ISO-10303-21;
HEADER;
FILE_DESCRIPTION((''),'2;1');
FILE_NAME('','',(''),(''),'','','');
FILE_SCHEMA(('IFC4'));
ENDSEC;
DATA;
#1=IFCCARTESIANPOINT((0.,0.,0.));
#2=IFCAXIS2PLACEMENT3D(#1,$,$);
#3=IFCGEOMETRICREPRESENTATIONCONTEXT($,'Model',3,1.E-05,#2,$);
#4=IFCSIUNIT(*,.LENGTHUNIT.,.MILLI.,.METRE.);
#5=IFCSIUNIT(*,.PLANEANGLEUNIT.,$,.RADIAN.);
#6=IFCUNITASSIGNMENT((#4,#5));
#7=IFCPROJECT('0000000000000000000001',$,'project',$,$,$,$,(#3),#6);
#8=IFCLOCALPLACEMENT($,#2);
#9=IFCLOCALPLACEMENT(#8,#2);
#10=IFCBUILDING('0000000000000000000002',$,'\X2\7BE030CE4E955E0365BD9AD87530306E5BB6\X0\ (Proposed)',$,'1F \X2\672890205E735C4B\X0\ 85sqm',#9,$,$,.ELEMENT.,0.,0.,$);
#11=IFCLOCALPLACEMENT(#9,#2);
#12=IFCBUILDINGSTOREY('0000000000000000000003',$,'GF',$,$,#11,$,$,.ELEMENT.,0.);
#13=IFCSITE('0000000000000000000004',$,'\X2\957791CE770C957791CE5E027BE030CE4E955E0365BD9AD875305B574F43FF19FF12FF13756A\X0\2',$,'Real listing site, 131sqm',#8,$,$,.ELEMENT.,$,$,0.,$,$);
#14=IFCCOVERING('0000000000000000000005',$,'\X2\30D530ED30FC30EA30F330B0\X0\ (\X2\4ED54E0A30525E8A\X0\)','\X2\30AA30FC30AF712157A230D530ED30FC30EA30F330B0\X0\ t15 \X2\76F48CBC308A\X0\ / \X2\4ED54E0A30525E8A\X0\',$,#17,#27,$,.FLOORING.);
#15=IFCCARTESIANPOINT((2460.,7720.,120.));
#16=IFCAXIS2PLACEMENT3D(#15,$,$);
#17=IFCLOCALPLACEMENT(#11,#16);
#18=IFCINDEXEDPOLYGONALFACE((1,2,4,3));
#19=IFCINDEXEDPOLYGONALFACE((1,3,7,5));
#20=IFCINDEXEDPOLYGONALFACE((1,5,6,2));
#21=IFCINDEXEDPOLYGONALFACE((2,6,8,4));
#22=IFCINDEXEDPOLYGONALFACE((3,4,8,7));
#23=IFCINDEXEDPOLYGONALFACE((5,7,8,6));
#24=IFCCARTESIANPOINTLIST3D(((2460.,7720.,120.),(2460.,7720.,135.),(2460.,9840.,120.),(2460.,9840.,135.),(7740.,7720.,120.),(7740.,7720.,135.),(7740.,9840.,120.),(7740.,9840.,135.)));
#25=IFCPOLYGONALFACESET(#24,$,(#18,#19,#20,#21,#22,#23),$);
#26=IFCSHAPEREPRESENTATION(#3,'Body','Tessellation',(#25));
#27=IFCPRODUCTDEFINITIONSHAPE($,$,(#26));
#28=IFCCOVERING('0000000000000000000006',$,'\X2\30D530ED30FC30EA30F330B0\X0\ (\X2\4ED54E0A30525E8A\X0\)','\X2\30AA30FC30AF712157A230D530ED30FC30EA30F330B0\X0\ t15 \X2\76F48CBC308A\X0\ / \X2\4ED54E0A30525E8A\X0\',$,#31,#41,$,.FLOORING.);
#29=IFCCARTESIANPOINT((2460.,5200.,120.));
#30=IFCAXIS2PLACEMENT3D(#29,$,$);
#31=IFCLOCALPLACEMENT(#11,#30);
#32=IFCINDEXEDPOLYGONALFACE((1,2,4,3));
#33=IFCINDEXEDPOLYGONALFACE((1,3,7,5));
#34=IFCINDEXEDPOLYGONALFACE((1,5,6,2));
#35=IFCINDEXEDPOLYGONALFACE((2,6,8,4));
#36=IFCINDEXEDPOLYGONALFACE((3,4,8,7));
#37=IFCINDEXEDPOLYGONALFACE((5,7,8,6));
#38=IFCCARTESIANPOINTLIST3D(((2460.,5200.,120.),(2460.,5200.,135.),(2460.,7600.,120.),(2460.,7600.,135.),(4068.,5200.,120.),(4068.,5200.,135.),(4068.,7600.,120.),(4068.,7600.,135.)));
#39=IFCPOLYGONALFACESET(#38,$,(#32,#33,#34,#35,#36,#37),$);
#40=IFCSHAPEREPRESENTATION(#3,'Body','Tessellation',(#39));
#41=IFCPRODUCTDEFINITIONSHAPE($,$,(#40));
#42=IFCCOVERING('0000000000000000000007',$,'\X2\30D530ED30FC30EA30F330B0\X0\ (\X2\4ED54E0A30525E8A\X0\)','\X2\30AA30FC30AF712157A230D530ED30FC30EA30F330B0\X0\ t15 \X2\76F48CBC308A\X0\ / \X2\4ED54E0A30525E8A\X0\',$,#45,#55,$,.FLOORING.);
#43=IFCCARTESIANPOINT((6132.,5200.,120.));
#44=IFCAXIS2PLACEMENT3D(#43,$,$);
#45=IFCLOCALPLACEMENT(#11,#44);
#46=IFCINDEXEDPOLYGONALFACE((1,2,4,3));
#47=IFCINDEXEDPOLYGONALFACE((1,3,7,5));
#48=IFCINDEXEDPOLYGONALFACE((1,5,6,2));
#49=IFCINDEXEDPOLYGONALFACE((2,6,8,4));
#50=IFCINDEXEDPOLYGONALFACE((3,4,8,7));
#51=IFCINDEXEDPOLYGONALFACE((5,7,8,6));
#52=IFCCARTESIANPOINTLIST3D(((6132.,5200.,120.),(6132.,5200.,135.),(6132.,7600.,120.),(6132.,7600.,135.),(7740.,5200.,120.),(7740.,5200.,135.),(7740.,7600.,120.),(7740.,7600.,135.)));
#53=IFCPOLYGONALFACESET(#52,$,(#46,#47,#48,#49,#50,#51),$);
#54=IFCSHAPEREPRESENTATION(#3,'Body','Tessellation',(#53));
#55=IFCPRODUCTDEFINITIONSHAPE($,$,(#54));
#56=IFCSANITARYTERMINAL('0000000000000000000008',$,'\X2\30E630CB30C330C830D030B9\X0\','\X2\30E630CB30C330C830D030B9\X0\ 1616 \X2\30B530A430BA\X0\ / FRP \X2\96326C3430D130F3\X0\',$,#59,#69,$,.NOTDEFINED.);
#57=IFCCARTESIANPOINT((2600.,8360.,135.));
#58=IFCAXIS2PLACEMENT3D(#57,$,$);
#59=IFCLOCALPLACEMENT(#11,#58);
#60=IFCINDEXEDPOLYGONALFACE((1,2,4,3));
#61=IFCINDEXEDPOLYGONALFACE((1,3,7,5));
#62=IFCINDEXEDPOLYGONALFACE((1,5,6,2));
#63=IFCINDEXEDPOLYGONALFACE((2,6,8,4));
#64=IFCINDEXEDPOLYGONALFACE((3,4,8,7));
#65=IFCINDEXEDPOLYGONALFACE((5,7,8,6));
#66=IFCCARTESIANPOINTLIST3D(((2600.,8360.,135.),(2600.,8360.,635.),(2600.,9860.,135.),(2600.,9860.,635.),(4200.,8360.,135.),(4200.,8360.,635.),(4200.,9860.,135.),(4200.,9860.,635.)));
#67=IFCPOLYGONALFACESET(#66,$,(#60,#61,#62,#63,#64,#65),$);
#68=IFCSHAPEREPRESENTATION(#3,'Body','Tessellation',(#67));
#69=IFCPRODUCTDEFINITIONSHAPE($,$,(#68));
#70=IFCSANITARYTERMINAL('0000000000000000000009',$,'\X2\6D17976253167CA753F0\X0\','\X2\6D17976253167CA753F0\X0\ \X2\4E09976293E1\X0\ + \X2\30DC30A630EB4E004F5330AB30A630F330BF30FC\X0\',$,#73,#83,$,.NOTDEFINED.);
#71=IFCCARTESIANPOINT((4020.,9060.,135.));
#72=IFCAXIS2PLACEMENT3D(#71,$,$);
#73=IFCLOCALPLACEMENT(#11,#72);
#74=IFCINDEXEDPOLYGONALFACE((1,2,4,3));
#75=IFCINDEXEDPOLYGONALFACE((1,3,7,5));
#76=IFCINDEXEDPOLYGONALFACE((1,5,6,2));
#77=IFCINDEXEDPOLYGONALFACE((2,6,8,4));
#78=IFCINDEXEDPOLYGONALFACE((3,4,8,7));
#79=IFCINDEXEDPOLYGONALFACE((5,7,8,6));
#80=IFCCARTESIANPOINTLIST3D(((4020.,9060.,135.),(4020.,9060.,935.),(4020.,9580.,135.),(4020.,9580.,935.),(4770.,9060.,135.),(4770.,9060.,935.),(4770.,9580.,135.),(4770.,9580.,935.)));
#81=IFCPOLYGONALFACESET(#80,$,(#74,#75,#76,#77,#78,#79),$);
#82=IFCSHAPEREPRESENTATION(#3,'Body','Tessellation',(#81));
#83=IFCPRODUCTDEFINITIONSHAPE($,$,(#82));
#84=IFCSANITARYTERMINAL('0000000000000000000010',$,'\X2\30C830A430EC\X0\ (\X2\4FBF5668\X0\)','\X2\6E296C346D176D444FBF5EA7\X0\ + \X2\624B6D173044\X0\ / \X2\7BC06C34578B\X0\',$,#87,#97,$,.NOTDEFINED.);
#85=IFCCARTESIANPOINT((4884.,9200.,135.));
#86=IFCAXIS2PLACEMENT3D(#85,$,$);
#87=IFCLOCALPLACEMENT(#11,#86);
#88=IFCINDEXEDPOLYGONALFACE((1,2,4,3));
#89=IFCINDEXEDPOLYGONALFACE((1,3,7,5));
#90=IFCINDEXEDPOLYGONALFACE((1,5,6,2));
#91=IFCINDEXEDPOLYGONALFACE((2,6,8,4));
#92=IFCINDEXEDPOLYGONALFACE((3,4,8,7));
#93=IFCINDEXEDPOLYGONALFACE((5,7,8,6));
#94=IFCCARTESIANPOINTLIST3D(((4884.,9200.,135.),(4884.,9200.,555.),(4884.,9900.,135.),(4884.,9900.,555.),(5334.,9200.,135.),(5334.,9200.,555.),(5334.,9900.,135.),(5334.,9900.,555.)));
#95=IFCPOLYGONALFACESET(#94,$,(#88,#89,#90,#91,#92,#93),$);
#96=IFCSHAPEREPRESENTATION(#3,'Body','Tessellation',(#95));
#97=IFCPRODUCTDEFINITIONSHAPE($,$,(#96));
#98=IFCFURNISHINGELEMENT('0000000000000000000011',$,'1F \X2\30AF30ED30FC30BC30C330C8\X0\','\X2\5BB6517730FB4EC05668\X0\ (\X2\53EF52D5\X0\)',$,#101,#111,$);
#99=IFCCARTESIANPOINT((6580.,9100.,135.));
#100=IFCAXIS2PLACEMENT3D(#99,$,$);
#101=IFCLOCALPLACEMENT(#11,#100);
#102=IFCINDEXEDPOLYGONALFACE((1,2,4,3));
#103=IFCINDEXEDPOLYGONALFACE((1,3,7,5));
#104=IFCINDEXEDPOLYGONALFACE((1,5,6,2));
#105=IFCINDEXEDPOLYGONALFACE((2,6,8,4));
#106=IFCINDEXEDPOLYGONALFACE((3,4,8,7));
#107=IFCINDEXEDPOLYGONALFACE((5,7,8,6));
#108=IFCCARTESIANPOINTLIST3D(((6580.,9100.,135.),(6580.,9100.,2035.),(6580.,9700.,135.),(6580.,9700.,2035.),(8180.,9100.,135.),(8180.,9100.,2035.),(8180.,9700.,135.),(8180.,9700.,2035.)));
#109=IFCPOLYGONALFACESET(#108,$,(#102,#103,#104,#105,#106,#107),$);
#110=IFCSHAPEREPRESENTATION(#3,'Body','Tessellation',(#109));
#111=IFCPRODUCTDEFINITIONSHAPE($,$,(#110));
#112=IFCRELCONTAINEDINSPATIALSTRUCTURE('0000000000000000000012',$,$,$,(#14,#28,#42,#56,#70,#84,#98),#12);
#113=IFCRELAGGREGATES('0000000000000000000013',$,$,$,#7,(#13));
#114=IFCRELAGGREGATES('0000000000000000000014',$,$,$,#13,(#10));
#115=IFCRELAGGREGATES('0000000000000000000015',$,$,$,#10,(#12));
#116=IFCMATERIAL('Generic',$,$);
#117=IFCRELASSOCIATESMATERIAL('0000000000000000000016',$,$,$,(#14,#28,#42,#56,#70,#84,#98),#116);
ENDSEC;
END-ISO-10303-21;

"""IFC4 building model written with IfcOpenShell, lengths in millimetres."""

from ifc_helpers import new_model, si_unit, frame, frame_2d, origin, place, context, project, spatial, rectangle, extrude, material, element, save


model = new_model("IFC4")

# Units and contexts
model_context = context("Model", 3, precision=1e-05, world=origin())
ifc_project = project(units=[si_unit("LENGTHUNIT", "METRE", prefix="MILLI"), si_unit("PLANEANGLEUNIT", "RADIAN")], contexts=[model_context])

# Site, building, storey
site_placement = place(None, origin())
site = spatial("IfcSite", under=ifc_project, at=site_placement, Name="長野県長野市篠ノ井布施高田字佃９２３番2", ObjectType="Real listing site, 131sqm", CompositionType="ELEMENT", RefElevation=0.0)
building_placement = place(site_placement, origin())
building = spatial("IfcBuilding", under=site, at=building_placement, Name="篠ノ井布施高田の家 (Proposed)", ObjectType="1F 木造平屋 85sqm", CompositionType="ELEMENT", ElevationOfRefHeight=0.0, ElevationOfTerrain=0.0)
storey_placement = place(building_placement, origin())
storey = spatial("IfcBuildingStorey", under=building, at=storey_placement, Name="GF", CompositionType="ELEMENT", Elevation=0.0)

# Coverings
ifc_material_1 = material(Name="Generic")
covering_1_placement = place(storey_placement, frame((2460.0, 7720.0, 120.0)))
element("IfcCovering", 1, at=covering_1_placement, inside=storey, material=ifc_material_1, Name="フローリング (仕上げ床)", Description="オーク無垢フローリング t15 直貼り / 仕上げ床", PredefinedType="FLOORING", context=model_context, shape_type="SweptSolid", body=[
    extrude(rectangle(XDim=5280.0, YDim=2120.0, at=frame_2d((2640.0, 1060.0))), frame((2460.0, 7720.0, 120.0)), (0.0, 0.0, 1.0), 15.0),
])
covering_2_placement = place(storey_placement, frame((2460.0, 5200.0, 120.0)))
element("IfcCovering", 2, at=covering_2_placement, inside=storey, material=ifc_material_1, Name="フローリング (仕上げ床)", Description="オーク無垢フローリング t15 直貼り / 仕上げ床", PredefinedType="FLOORING", context=model_context, shape_type="SweptSolid", body=[
    extrude(rectangle(XDim=1608.0, YDim=2400.0, at=frame_2d((804.0, 1200.0))), frame((2460.0, 5200.0, 120.0)), (0.0, 0.0, 1.0), 15.0),
])
covering_3_placement = place(storey_placement, frame((6132.0, 5200.0, 120.0)))
element("IfcCovering", 3, at=covering_3_placement, inside=storey, material=ifc_material_1, Name="フローリング (仕上げ床)", Description="オーク無垢フローリング t15 直貼り / 仕上げ床", PredefinedType="FLOORING", context=model_context, shape_type="SweptSolid", body=[
    extrude(rectangle(XDim=1608.0, YDim=2400.0, at=frame_2d((804.0, 1200.0))), frame((6132.0, 5200.0, 120.0)), (0.0, 0.0, 1.0), 15.0),
])

# Sanitary terminals
sanitary_terminal_1_placement = place(storey_placement, frame((2600.0, 8360.0, 135.0)))
element("IfcSanitaryTerminal", 4, at=sanitary_terminal_1_placement, inside=storey, material=ifc_material_1, Name="ユニットバス", Description="ユニットバス 1616 サイズ / FRP 防水パン", PredefinedType="NOTDEFINED", context=model_context, shape_type="SweptSolid", body=[
    extrude(rectangle(XDim=1600.0, YDim=1500.0, at=frame_2d((800.0, 750.0))), frame((2600.0, 8360.0, 135.0)), (0.0, 0.0, 1.0), 500.0),
])
sanitary_terminal_2_placement = place(storey_placement, frame((4020.0, 9060.0, 135.0)))
element("IfcSanitaryTerminal", 5, at=sanitary_terminal_2_placement, inside=storey, material=ifc_material_1, Name="洗面化粧台", Description="洗面化粧台 三面鏡 + ボウル一体カウンター", PredefinedType="NOTDEFINED", context=model_context, shape_type="SweptSolid", body=[
    extrude(rectangle(XDim=750.0, YDim=520.0, at=frame_2d((375.0, 260.0))), frame((4020.0, 9060.0, 135.0)), (0.0, 0.0, 1.0), 800.0),
])
sanitary_terminal_3_placement = place(storey_placement, frame((4884.0, 9200.0, 135.0)))
element("IfcSanitaryTerminal", 6, at=sanitary_terminal_3_placement, inside=storey, material=ifc_material_1, Name="トイレ (便器)", Description="温水洗浄便座 + 手洗い / 節水型", PredefinedType="NOTDEFINED", context=model_context, shape_type="SweptSolid", body=[
    extrude(rectangle(XDim=450.0, YDim=700.0, at=frame_2d((225.0, 350.0))), frame((4884.0, 9200.0, 135.0)), (0.0, 0.0, 1.0), 420.0),
])

# Furnishing element
furnishing_placement = place(storey_placement, frame((6580.0, 9100.0, 135.0)))
element("IfcFurnishingElement", 7, at=furnishing_placement, inside=storey, material=ifc_material_1, Name="1F クローゼット", Description="家具・什器 (可動)", context=model_context, shape_type="SweptSolid", body=[
    extrude(rectangle(XDim=1600.0, YDim=600.0, at=frame_2d((800.0, 300.0))), frame((6580.0, 9100.0, 135.0)), (0.0, 0.0, 1.0), 1900.0),
])

save(model, "model.ifc")
